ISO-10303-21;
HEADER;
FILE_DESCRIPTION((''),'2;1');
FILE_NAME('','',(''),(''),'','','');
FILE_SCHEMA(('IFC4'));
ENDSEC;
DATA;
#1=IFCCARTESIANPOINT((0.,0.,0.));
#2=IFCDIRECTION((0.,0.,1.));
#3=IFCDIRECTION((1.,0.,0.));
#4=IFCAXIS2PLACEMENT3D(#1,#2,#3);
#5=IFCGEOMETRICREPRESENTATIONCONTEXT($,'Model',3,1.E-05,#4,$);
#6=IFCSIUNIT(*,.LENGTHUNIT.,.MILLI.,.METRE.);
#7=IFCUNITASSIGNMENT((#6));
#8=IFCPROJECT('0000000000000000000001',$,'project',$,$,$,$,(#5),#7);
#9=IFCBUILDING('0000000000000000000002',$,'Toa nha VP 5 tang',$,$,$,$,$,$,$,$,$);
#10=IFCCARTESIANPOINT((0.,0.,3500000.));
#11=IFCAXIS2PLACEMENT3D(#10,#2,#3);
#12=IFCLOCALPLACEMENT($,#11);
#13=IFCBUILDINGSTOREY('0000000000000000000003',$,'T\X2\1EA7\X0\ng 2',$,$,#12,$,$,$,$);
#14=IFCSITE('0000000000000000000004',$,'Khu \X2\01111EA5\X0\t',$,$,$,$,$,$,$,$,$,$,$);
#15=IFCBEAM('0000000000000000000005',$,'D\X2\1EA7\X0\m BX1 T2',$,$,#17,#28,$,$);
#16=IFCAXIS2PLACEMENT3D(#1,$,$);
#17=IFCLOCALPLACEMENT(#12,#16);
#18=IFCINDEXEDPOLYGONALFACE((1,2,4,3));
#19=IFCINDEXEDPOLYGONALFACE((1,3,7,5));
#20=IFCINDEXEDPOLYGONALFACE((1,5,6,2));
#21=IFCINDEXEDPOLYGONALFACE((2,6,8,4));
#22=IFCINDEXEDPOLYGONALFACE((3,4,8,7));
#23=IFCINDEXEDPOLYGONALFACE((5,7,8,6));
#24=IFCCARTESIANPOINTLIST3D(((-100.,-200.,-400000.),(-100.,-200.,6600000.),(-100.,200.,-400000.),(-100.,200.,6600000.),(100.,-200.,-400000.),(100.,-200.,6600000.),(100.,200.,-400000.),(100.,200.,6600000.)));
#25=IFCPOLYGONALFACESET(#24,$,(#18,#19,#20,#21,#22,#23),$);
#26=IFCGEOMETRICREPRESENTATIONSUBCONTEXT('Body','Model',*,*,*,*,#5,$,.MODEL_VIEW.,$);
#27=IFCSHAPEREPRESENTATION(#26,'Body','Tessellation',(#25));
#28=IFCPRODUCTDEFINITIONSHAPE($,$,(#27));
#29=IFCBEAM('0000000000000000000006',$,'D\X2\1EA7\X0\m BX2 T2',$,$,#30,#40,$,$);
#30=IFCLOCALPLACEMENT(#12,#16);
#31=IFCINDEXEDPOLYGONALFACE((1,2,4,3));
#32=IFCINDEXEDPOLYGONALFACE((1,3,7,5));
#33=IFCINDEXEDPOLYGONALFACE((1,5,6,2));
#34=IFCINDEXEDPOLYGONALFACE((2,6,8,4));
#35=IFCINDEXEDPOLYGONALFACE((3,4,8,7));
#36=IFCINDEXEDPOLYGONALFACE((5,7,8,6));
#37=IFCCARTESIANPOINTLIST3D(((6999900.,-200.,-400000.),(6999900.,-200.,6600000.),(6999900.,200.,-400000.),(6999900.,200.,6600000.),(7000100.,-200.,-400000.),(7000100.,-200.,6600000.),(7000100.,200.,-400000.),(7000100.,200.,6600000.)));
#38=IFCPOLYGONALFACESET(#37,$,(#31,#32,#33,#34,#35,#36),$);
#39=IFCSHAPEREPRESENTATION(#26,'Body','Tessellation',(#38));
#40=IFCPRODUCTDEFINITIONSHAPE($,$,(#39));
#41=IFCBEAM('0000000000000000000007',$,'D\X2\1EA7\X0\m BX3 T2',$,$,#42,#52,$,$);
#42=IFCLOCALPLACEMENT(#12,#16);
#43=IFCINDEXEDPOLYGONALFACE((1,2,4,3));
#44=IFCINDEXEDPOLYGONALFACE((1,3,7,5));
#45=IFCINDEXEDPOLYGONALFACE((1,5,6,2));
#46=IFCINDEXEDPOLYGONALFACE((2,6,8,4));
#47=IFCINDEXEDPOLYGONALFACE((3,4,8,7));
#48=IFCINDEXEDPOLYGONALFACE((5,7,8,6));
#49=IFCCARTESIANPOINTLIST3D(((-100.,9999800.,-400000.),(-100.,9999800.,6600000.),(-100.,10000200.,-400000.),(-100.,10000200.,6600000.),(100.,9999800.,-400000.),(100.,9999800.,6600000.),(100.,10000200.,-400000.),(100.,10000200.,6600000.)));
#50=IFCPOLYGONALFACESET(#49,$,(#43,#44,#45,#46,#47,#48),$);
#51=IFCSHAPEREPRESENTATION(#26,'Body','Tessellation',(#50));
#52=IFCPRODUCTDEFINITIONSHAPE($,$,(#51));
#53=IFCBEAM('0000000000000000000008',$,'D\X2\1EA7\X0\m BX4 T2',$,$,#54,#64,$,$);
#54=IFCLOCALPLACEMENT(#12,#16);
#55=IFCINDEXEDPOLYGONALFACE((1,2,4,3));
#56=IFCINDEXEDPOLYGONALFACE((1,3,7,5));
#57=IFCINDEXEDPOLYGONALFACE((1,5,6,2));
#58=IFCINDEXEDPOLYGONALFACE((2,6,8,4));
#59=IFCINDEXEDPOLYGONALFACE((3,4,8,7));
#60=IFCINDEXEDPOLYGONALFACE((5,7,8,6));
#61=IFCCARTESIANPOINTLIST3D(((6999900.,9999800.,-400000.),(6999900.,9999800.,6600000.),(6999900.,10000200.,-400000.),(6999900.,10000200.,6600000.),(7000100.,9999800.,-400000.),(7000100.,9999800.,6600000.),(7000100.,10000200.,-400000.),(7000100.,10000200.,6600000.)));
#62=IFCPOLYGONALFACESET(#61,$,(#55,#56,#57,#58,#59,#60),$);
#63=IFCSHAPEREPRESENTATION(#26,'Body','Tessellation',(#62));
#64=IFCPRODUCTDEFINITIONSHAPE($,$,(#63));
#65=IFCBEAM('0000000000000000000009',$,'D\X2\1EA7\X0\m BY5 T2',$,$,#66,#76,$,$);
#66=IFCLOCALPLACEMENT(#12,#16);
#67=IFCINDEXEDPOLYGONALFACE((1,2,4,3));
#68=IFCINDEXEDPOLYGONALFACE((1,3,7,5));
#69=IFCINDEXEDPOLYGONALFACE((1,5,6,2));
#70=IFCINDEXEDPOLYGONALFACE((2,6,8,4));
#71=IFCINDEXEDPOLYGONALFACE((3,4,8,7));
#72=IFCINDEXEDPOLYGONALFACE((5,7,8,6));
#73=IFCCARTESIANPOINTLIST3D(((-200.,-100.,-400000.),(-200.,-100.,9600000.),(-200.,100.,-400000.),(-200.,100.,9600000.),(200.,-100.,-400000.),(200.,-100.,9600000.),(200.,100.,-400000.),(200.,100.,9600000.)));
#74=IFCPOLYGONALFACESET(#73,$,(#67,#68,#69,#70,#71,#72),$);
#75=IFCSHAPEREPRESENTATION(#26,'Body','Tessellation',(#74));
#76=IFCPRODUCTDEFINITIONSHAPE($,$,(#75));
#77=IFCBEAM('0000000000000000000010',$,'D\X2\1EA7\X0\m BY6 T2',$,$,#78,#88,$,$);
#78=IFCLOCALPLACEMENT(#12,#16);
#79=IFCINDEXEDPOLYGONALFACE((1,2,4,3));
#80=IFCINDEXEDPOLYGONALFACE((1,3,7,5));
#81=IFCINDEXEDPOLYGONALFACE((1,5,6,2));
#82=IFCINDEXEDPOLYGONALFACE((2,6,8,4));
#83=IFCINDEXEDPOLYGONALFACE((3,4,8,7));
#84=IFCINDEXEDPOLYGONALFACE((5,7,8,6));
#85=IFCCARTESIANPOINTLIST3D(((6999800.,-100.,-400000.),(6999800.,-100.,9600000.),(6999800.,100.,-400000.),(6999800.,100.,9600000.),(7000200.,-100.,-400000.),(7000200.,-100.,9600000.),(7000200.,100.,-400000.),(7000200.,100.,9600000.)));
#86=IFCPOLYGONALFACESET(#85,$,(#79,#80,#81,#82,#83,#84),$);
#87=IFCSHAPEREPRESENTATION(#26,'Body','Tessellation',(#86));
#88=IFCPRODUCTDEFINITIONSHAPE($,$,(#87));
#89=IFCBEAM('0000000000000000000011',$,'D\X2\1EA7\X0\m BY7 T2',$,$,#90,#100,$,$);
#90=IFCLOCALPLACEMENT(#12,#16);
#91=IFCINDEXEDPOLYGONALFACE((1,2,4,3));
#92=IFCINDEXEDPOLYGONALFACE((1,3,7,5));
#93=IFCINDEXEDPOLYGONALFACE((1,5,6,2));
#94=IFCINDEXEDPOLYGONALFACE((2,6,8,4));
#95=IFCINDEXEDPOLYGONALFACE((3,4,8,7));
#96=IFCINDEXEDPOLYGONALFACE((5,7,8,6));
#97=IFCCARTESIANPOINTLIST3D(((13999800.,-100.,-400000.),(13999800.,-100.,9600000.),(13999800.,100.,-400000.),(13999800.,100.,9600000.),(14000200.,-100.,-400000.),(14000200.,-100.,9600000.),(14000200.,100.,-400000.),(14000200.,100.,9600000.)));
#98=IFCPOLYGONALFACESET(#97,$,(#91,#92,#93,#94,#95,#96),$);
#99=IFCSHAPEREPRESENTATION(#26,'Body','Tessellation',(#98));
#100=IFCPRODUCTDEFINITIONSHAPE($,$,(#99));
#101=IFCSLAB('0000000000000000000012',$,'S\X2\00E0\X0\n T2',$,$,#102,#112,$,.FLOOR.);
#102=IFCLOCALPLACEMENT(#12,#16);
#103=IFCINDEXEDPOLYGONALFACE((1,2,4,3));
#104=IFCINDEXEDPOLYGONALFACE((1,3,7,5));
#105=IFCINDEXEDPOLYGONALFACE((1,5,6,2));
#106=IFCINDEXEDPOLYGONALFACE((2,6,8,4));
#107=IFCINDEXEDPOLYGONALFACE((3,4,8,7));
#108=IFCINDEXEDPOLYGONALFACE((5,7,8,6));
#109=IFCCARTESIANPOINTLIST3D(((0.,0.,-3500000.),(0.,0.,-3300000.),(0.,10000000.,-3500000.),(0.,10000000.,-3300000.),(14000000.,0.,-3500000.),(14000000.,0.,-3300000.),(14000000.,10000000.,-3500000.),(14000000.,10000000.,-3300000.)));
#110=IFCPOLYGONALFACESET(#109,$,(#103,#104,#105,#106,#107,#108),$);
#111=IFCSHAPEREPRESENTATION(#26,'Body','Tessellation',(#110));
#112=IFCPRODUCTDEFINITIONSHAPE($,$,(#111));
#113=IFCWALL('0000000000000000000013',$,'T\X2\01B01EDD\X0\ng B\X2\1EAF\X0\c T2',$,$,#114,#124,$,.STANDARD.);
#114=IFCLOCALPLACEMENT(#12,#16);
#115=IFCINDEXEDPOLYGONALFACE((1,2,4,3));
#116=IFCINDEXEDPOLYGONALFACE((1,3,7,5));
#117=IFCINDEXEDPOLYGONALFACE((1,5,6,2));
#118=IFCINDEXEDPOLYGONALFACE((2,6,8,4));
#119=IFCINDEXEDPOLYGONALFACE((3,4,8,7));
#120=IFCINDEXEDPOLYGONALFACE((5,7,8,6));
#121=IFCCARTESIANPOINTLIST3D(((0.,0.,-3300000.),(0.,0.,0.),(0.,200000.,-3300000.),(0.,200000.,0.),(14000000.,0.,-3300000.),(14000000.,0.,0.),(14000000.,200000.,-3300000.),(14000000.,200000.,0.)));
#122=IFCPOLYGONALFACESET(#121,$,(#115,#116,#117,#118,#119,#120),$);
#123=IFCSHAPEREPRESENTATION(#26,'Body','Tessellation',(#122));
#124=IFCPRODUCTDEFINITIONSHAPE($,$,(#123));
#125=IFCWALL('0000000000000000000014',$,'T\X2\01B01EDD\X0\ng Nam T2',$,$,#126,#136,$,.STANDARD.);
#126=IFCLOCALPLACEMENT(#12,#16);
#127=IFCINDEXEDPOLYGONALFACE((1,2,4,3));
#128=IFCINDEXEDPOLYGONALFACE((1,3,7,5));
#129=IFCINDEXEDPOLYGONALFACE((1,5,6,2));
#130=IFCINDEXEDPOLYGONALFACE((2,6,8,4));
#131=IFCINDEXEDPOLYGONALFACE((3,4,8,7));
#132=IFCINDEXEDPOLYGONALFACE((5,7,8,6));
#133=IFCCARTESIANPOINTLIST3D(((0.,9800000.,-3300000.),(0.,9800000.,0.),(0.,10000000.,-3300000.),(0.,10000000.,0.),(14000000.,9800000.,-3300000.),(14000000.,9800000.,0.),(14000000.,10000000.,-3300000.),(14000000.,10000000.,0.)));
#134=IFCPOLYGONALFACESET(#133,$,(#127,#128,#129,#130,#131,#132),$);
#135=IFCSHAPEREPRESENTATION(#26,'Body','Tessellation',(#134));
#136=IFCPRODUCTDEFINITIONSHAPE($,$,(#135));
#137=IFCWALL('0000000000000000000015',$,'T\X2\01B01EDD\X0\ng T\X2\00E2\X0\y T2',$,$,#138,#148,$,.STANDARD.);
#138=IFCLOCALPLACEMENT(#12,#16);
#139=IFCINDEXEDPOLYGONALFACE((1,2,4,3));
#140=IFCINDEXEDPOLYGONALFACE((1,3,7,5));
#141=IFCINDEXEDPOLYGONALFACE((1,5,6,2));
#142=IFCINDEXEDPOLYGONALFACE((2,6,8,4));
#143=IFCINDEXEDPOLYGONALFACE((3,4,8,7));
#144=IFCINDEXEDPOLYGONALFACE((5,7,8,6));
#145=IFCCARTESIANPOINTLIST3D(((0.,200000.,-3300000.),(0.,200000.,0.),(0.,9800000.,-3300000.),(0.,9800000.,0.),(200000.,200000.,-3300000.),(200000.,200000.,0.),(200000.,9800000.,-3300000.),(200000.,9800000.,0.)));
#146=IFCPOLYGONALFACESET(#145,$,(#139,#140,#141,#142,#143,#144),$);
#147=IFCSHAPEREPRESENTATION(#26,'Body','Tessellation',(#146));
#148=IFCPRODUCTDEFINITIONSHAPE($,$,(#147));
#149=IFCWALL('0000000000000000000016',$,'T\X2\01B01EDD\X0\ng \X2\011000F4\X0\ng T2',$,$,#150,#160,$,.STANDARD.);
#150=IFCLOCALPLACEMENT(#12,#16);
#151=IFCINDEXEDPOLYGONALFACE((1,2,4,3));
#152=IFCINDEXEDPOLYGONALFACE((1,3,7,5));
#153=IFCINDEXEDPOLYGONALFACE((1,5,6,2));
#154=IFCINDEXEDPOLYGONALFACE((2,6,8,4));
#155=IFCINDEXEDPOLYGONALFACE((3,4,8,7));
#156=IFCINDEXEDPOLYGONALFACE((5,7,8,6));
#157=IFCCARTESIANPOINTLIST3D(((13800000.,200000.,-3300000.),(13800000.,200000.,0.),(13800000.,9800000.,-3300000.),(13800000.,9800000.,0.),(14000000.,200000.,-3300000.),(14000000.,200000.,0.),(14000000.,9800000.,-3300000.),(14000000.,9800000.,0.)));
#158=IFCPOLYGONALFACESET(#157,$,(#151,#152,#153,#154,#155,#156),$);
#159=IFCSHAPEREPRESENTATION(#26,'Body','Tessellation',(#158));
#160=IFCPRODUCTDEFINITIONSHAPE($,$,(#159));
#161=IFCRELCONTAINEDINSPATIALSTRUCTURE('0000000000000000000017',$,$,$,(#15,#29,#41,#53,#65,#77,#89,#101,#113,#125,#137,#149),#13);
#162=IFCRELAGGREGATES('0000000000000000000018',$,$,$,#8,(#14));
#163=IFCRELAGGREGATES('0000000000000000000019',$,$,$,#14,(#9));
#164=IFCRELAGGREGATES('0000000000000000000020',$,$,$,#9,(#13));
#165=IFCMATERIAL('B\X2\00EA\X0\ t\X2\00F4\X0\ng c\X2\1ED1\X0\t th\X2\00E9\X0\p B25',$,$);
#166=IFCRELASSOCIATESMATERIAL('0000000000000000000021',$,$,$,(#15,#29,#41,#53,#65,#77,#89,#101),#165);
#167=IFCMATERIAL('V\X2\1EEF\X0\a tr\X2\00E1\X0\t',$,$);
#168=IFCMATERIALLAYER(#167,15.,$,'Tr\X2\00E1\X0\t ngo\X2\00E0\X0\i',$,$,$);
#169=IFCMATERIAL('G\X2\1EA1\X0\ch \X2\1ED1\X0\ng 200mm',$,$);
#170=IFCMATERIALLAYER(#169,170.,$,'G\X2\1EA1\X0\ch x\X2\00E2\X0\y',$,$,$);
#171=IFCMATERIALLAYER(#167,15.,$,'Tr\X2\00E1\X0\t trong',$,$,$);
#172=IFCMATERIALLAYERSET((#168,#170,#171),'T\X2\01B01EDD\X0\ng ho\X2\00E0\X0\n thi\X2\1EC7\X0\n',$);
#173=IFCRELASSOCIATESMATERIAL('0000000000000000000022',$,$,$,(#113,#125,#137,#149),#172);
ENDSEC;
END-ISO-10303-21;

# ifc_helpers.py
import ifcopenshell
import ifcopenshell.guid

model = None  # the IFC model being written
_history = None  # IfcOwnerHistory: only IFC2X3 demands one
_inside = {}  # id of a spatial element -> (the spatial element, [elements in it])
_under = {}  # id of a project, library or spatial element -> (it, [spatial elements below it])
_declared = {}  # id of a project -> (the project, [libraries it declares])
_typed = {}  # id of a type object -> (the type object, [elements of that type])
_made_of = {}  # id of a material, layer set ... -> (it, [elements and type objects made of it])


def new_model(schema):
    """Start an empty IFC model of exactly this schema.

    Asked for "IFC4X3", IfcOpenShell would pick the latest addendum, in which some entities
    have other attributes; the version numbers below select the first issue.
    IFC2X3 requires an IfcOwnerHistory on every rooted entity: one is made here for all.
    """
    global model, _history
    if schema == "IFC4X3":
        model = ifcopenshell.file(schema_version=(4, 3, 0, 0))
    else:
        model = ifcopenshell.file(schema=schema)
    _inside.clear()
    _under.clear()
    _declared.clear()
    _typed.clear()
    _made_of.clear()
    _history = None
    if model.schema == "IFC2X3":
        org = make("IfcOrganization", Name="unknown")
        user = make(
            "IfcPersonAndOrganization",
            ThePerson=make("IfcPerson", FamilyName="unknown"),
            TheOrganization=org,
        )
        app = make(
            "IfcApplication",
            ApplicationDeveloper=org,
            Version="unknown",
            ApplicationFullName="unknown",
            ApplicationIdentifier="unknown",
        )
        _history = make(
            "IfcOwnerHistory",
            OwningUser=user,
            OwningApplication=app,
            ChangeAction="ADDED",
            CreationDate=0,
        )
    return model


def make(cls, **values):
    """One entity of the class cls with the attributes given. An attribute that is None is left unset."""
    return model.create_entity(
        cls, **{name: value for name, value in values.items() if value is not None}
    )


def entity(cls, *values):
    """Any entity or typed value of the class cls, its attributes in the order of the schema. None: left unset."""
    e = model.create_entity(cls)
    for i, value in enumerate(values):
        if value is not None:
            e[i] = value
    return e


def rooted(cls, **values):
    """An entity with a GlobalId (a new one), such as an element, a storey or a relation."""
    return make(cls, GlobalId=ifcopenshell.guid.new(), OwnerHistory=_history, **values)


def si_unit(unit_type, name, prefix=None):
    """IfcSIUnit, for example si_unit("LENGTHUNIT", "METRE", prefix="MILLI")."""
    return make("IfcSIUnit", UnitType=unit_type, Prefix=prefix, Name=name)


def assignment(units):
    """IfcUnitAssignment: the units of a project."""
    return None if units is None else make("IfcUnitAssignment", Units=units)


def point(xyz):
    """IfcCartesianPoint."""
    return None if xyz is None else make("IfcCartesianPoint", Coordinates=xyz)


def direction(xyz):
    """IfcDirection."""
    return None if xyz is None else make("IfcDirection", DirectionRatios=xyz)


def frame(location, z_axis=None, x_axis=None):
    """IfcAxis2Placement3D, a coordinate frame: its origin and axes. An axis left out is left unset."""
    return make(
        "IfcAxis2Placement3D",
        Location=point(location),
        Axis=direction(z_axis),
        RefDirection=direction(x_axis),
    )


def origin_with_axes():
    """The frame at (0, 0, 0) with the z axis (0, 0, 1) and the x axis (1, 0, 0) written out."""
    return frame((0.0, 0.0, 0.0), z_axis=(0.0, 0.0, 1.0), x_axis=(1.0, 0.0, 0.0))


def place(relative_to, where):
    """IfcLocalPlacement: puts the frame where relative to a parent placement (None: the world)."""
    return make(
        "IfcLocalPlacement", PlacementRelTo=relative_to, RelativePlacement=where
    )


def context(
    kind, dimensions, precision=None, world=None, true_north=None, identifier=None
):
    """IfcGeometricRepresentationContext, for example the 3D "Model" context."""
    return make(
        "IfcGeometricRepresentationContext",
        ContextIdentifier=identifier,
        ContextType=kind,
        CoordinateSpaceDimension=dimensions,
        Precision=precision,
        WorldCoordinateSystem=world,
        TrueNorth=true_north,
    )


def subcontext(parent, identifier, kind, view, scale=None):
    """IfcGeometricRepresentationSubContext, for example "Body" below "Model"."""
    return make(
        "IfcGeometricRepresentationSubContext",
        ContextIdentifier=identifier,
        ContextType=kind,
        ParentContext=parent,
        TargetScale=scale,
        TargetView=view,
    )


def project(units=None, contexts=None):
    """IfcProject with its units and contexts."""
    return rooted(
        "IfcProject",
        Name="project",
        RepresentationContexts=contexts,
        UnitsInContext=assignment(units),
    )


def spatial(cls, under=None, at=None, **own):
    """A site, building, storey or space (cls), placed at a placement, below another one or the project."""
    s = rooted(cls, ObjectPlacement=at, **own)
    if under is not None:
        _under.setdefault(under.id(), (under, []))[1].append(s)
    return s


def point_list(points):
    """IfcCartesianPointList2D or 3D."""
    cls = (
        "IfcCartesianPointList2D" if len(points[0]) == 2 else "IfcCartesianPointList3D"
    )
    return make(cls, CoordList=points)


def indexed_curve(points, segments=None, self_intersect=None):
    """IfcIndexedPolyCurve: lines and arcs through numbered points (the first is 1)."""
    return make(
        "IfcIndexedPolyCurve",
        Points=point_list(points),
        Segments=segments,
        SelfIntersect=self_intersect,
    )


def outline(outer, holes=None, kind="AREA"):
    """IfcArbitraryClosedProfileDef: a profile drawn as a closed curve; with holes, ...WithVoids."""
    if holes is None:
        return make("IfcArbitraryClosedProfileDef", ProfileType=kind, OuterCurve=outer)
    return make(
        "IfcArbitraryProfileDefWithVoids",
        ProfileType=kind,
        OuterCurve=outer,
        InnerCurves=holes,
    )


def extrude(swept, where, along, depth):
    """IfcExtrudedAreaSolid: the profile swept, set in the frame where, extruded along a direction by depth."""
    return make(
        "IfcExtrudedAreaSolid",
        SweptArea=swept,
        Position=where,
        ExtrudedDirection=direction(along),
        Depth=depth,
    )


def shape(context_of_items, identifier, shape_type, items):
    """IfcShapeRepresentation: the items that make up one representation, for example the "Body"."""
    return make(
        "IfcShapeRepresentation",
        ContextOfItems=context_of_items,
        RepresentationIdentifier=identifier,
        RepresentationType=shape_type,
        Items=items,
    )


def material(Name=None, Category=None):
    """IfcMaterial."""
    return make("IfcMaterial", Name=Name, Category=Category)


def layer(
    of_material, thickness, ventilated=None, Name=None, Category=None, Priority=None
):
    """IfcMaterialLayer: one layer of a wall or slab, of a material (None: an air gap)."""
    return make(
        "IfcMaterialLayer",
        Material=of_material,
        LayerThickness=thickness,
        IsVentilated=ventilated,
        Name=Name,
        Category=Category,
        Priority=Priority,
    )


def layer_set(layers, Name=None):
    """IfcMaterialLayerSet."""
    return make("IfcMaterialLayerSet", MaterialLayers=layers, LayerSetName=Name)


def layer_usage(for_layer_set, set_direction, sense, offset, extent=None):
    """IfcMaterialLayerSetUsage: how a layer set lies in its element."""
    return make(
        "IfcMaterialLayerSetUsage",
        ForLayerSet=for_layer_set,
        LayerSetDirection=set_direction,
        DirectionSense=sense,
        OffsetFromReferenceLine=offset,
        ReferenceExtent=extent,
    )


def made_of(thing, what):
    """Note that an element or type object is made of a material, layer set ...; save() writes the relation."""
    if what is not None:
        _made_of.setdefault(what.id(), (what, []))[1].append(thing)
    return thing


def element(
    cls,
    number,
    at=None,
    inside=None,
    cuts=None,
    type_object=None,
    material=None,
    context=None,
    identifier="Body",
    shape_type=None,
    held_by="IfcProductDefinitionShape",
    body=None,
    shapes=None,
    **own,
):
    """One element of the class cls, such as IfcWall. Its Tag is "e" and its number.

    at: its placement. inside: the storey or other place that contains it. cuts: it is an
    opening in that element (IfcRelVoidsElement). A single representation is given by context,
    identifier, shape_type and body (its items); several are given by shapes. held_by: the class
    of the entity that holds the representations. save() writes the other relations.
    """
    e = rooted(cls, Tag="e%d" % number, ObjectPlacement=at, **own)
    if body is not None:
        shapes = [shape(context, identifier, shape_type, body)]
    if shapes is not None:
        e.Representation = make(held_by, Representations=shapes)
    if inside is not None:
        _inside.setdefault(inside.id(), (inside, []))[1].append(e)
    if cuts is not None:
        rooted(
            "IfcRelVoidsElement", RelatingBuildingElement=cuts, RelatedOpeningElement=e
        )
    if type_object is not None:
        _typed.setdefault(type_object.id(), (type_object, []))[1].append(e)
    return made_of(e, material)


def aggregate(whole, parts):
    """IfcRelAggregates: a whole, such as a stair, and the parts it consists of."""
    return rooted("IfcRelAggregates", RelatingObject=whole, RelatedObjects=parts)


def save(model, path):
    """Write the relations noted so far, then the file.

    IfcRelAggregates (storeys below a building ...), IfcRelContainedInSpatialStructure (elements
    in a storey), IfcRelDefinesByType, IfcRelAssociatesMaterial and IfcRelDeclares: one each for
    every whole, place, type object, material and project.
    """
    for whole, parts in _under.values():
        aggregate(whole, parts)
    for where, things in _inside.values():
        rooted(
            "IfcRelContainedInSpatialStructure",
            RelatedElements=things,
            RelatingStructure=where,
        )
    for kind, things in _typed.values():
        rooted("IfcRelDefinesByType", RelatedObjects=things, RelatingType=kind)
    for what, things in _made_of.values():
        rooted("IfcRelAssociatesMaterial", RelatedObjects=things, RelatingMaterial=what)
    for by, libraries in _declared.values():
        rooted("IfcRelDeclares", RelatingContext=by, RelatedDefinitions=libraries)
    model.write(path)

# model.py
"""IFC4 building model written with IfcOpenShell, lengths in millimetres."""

from ifc_helpers import new_model, entity, si_unit, frame, origin_with_axes, place, context, subcontext, project, spatial, indexed_curve, outline, extrude, material, layer, layer_set, layer_usage, element, save


model = new_model("IFC4")

# Units and contexts
model_context = context("Model", 3, precision=1e-05, world=origin_with_axes())
body_context = subcontext(model_context, "Body", "Model", "MODEL_VIEW")
ifc_project = project(units=[si_unit("LENGTHUNIT", "METRE", prefix="MILLI")], contexts=[model_context])

# Site, building, storey
site = spatial("IfcSite", under=ifc_project, Name="Khu đất")
building = spatial("IfcBuilding", under=site, Name="Toa nha VP 5 tang")
storey_placement = place(None, frame((0.0, 0.0, 3500000.0), z_axis=(0.0, 0.0, 1.0), x_axis=(1.0, 0.0, 0.0)))
storey = spatial("IfcBuildingStorey", under=building, at=storey_placement, Name="Tầng 2")

# Beams
ifc_material_1 = material(Name="Bê tông cốt thép B25")
for number, where, z_axis, x_axis, name in (
    (1, (0.0, 0.0, -400000.0), (0.0, 0.0, 1.0), (1.0, 0.0, 0.0), "Dầm BX1 T2"),
    (2, (7000000.0, 0.0, -400000.0), (0.0, 0.0, 1.0), (1.0, 0.0, 0.0), "Dầm BX2 T2"),
    (3, (0.0, 10000000.0, -400000.0), (0.0, 0.0, 1.0), (1.0, 0.0, 0.0), "Dầm BX3 T2"),
    (4, (7000000.0, 10000000.0, -400000.0), (0.0, 0.0, 1.0), (1.0, 0.0, 0.0), "Dầm BX4 T2"),
):
    element("IfcBeam", number, at=place(storey_placement, frame(where, z_axis=z_axis, x_axis=x_axis)), inside=storey, material=ifc_material_1, Name=name, context=body_context, shape_type="SweptSolid", body=[
        extrude(entity("IfcRectangleProfileDef", None, None, None, 200.0, 400.0), origin_with_axes(), (0.0, 0.0, 1.0), 7000000.0),
    ])
for number, where, z_axis, x_axis, name in (
    (5, (0.0, 0.0, -400000.0), (0.0, 0.0, 1.0), (0.0, 1.0, 0.0), "Dầm BY5 T2"),
    (6, (7000000.0, 0.0, -400000.0), (0.0, 0.0, 1.0), (0.0, 1.0, 0.0), "Dầm BY6 T2"),
    (7, (14000000.0, 0.0, -400000.0), (0.0, 0.0, 1.0), (0.0, 1.0, 0.0), "Dầm BY7 T2"),
):
    element("IfcBeam", number, at=place(storey_placement, frame(where, z_axis=z_axis, x_axis=x_axis)), inside=storey, material=ifc_material_1, Name=name, context=body_context, shape_type="SweptSolid", body=[
        extrude(entity("IfcRectangleProfileDef", None, None, None, 200.0, 400.0), origin_with_axes(), (0.0, 0.0, 1.0), 10000000.0),
    ])

# Slab
slab_placement = place(storey_placement, frame((0.0, 0.0, -3500000.0), z_axis=(0.0, 0.0, 1.0), x_axis=(1.0, 0.0, 0.0)))
element("IfcSlab", 8, at=slab_placement, inside=storey, material=ifc_material_1, Name="Sàn T2", PredefinedType="FLOOR", context=body_context, shape_type="SweptSolid", body=[
    extrude(outline(indexed_curve([(0.0, 0.0), (14000000.0, 0.0), (14000000.0, 10000000.0), (0.0, 10000000.0), (0.0, 0.0)])), None, (0.0, 0.0, 1.0), 200000.0),
])

# Walls
ifc_material_2 = material(Name="Vữa trát")
ifc_layer_1 = layer(ifc_material_2, 15.0, Name="Trát ngoài")
ifc_material_3 = material(Name="Gạch ống 200mm")
ifc_layer_2 = layer(ifc_material_3, 170.0, Name="Gạch xây")
ifc_layer_3 = layer(ifc_material_2, 15.0, Name="Trát trong")
ifc_layer_set = layer_set([ifc_layer_1, ifc_layer_2, ifc_layer_3], Name="Tường hoàn thiện")
ifc_layer_usage_1 = layer_usage(ifc_layer_set, "AXIS2", "POSITIVE", 0.0)
wall_1_placement = place(storey_placement, frame((0.0, 0.0, -3300000.0), z_axis=(0.0, 0.0, 1.0), x_axis=(1.0, 0.0, 0.0)))
element("IfcWall", 9, at=wall_1_placement, inside=storey, material=ifc_layer_usage_1, Name="Tường Bắc T2", PredefinedType="STANDARD", context=body_context, shape_type="SweptSolid", body=[
    extrude(outline(indexed_curve([(0.0, 0.0), (0.0, 200000.0), (14000000.0, 200000.0), (14000000.0, 0.0), (0.0, 0.0)], self_intersect=False)), origin_with_axes(), (0.0, 0.0, 1.0), 3300000.0),
])
ifc_layer_usage_2 = layer_usage(ifc_layer_set, "AXIS2", "POSITIVE", 0.0)
wall_2_placement = place(storey_placement, frame((0.0, 9800000.0, -3300000.0), z_axis=(0.0, 0.0, 1.0), x_axis=(1.0, 0.0, 0.0)))
element("IfcWall", 10, at=wall_2_placement, inside=storey, material=ifc_layer_usage_2, Name="Tường Nam T2", PredefinedType="STANDARD", context=body_context, shape_type="SweptSolid", body=[
    extrude(outline(indexed_curve([(0.0, 0.0), (0.0, 200000.0), (14000000.0, 200000.0), (14000000.0, 0.0), (0.0, 0.0)], self_intersect=False)), origin_with_axes(), (0.0, 0.0, 1.0), 3300000.0),
])
ifc_layer_usage_3 = layer_usage(ifc_layer_set, "AXIS2", "POSITIVE", 0.0)
wall_3_placement = place(storey_placement, frame((0.0, 200000.0, -3300000.0), z_axis=(0.0, 0.0, 1.0), x_axis=(1.0, 0.0, 0.0)))
element("IfcWall", 11, at=wall_3_placement, inside=storey, material=ifc_layer_usage_3, Name="Tường Tây T2", PredefinedType="STANDARD", context=body_context, shape_type="SweptSolid", body=[
    extrude(outline(indexed_curve([(0.0, 0.0), (0.0, 9600000.0), (200000.0, 9600000.0), (200000.0, 0.0), (0.0, 0.0)], self_intersect=False)), origin_with_axes(), (0.0, 0.0, 1.0), 3300000.0),
])
ifc_layer_usage_4 = layer_usage(ifc_layer_set, "AXIS2", "POSITIVE", 0.0)
wall_4_placement = place(storey_placement, frame((13800000.0, 200000.0, -3300000.0), z_axis=(0.0, 0.0, 1.0), x_axis=(1.0, 0.0, 0.0)))
element("IfcWall", 12, at=wall_4_placement, inside=storey, material=ifc_layer_usage_4, Name="Tường Đông T2", PredefinedType="STANDARD", context=body_context, shape_type="SweptSolid", body=[
    extrude(outline(indexed_curve([(0.0, 0.0), (0.0, 9600000.0), (200000.0, 9600000.0), (200000.0, 0.0), (0.0, 0.0)], self_intersect=False)), origin_with_axes(), (0.0, 0.0, 1.0), 3300000.0),
])

save(model, "model.ifc")
